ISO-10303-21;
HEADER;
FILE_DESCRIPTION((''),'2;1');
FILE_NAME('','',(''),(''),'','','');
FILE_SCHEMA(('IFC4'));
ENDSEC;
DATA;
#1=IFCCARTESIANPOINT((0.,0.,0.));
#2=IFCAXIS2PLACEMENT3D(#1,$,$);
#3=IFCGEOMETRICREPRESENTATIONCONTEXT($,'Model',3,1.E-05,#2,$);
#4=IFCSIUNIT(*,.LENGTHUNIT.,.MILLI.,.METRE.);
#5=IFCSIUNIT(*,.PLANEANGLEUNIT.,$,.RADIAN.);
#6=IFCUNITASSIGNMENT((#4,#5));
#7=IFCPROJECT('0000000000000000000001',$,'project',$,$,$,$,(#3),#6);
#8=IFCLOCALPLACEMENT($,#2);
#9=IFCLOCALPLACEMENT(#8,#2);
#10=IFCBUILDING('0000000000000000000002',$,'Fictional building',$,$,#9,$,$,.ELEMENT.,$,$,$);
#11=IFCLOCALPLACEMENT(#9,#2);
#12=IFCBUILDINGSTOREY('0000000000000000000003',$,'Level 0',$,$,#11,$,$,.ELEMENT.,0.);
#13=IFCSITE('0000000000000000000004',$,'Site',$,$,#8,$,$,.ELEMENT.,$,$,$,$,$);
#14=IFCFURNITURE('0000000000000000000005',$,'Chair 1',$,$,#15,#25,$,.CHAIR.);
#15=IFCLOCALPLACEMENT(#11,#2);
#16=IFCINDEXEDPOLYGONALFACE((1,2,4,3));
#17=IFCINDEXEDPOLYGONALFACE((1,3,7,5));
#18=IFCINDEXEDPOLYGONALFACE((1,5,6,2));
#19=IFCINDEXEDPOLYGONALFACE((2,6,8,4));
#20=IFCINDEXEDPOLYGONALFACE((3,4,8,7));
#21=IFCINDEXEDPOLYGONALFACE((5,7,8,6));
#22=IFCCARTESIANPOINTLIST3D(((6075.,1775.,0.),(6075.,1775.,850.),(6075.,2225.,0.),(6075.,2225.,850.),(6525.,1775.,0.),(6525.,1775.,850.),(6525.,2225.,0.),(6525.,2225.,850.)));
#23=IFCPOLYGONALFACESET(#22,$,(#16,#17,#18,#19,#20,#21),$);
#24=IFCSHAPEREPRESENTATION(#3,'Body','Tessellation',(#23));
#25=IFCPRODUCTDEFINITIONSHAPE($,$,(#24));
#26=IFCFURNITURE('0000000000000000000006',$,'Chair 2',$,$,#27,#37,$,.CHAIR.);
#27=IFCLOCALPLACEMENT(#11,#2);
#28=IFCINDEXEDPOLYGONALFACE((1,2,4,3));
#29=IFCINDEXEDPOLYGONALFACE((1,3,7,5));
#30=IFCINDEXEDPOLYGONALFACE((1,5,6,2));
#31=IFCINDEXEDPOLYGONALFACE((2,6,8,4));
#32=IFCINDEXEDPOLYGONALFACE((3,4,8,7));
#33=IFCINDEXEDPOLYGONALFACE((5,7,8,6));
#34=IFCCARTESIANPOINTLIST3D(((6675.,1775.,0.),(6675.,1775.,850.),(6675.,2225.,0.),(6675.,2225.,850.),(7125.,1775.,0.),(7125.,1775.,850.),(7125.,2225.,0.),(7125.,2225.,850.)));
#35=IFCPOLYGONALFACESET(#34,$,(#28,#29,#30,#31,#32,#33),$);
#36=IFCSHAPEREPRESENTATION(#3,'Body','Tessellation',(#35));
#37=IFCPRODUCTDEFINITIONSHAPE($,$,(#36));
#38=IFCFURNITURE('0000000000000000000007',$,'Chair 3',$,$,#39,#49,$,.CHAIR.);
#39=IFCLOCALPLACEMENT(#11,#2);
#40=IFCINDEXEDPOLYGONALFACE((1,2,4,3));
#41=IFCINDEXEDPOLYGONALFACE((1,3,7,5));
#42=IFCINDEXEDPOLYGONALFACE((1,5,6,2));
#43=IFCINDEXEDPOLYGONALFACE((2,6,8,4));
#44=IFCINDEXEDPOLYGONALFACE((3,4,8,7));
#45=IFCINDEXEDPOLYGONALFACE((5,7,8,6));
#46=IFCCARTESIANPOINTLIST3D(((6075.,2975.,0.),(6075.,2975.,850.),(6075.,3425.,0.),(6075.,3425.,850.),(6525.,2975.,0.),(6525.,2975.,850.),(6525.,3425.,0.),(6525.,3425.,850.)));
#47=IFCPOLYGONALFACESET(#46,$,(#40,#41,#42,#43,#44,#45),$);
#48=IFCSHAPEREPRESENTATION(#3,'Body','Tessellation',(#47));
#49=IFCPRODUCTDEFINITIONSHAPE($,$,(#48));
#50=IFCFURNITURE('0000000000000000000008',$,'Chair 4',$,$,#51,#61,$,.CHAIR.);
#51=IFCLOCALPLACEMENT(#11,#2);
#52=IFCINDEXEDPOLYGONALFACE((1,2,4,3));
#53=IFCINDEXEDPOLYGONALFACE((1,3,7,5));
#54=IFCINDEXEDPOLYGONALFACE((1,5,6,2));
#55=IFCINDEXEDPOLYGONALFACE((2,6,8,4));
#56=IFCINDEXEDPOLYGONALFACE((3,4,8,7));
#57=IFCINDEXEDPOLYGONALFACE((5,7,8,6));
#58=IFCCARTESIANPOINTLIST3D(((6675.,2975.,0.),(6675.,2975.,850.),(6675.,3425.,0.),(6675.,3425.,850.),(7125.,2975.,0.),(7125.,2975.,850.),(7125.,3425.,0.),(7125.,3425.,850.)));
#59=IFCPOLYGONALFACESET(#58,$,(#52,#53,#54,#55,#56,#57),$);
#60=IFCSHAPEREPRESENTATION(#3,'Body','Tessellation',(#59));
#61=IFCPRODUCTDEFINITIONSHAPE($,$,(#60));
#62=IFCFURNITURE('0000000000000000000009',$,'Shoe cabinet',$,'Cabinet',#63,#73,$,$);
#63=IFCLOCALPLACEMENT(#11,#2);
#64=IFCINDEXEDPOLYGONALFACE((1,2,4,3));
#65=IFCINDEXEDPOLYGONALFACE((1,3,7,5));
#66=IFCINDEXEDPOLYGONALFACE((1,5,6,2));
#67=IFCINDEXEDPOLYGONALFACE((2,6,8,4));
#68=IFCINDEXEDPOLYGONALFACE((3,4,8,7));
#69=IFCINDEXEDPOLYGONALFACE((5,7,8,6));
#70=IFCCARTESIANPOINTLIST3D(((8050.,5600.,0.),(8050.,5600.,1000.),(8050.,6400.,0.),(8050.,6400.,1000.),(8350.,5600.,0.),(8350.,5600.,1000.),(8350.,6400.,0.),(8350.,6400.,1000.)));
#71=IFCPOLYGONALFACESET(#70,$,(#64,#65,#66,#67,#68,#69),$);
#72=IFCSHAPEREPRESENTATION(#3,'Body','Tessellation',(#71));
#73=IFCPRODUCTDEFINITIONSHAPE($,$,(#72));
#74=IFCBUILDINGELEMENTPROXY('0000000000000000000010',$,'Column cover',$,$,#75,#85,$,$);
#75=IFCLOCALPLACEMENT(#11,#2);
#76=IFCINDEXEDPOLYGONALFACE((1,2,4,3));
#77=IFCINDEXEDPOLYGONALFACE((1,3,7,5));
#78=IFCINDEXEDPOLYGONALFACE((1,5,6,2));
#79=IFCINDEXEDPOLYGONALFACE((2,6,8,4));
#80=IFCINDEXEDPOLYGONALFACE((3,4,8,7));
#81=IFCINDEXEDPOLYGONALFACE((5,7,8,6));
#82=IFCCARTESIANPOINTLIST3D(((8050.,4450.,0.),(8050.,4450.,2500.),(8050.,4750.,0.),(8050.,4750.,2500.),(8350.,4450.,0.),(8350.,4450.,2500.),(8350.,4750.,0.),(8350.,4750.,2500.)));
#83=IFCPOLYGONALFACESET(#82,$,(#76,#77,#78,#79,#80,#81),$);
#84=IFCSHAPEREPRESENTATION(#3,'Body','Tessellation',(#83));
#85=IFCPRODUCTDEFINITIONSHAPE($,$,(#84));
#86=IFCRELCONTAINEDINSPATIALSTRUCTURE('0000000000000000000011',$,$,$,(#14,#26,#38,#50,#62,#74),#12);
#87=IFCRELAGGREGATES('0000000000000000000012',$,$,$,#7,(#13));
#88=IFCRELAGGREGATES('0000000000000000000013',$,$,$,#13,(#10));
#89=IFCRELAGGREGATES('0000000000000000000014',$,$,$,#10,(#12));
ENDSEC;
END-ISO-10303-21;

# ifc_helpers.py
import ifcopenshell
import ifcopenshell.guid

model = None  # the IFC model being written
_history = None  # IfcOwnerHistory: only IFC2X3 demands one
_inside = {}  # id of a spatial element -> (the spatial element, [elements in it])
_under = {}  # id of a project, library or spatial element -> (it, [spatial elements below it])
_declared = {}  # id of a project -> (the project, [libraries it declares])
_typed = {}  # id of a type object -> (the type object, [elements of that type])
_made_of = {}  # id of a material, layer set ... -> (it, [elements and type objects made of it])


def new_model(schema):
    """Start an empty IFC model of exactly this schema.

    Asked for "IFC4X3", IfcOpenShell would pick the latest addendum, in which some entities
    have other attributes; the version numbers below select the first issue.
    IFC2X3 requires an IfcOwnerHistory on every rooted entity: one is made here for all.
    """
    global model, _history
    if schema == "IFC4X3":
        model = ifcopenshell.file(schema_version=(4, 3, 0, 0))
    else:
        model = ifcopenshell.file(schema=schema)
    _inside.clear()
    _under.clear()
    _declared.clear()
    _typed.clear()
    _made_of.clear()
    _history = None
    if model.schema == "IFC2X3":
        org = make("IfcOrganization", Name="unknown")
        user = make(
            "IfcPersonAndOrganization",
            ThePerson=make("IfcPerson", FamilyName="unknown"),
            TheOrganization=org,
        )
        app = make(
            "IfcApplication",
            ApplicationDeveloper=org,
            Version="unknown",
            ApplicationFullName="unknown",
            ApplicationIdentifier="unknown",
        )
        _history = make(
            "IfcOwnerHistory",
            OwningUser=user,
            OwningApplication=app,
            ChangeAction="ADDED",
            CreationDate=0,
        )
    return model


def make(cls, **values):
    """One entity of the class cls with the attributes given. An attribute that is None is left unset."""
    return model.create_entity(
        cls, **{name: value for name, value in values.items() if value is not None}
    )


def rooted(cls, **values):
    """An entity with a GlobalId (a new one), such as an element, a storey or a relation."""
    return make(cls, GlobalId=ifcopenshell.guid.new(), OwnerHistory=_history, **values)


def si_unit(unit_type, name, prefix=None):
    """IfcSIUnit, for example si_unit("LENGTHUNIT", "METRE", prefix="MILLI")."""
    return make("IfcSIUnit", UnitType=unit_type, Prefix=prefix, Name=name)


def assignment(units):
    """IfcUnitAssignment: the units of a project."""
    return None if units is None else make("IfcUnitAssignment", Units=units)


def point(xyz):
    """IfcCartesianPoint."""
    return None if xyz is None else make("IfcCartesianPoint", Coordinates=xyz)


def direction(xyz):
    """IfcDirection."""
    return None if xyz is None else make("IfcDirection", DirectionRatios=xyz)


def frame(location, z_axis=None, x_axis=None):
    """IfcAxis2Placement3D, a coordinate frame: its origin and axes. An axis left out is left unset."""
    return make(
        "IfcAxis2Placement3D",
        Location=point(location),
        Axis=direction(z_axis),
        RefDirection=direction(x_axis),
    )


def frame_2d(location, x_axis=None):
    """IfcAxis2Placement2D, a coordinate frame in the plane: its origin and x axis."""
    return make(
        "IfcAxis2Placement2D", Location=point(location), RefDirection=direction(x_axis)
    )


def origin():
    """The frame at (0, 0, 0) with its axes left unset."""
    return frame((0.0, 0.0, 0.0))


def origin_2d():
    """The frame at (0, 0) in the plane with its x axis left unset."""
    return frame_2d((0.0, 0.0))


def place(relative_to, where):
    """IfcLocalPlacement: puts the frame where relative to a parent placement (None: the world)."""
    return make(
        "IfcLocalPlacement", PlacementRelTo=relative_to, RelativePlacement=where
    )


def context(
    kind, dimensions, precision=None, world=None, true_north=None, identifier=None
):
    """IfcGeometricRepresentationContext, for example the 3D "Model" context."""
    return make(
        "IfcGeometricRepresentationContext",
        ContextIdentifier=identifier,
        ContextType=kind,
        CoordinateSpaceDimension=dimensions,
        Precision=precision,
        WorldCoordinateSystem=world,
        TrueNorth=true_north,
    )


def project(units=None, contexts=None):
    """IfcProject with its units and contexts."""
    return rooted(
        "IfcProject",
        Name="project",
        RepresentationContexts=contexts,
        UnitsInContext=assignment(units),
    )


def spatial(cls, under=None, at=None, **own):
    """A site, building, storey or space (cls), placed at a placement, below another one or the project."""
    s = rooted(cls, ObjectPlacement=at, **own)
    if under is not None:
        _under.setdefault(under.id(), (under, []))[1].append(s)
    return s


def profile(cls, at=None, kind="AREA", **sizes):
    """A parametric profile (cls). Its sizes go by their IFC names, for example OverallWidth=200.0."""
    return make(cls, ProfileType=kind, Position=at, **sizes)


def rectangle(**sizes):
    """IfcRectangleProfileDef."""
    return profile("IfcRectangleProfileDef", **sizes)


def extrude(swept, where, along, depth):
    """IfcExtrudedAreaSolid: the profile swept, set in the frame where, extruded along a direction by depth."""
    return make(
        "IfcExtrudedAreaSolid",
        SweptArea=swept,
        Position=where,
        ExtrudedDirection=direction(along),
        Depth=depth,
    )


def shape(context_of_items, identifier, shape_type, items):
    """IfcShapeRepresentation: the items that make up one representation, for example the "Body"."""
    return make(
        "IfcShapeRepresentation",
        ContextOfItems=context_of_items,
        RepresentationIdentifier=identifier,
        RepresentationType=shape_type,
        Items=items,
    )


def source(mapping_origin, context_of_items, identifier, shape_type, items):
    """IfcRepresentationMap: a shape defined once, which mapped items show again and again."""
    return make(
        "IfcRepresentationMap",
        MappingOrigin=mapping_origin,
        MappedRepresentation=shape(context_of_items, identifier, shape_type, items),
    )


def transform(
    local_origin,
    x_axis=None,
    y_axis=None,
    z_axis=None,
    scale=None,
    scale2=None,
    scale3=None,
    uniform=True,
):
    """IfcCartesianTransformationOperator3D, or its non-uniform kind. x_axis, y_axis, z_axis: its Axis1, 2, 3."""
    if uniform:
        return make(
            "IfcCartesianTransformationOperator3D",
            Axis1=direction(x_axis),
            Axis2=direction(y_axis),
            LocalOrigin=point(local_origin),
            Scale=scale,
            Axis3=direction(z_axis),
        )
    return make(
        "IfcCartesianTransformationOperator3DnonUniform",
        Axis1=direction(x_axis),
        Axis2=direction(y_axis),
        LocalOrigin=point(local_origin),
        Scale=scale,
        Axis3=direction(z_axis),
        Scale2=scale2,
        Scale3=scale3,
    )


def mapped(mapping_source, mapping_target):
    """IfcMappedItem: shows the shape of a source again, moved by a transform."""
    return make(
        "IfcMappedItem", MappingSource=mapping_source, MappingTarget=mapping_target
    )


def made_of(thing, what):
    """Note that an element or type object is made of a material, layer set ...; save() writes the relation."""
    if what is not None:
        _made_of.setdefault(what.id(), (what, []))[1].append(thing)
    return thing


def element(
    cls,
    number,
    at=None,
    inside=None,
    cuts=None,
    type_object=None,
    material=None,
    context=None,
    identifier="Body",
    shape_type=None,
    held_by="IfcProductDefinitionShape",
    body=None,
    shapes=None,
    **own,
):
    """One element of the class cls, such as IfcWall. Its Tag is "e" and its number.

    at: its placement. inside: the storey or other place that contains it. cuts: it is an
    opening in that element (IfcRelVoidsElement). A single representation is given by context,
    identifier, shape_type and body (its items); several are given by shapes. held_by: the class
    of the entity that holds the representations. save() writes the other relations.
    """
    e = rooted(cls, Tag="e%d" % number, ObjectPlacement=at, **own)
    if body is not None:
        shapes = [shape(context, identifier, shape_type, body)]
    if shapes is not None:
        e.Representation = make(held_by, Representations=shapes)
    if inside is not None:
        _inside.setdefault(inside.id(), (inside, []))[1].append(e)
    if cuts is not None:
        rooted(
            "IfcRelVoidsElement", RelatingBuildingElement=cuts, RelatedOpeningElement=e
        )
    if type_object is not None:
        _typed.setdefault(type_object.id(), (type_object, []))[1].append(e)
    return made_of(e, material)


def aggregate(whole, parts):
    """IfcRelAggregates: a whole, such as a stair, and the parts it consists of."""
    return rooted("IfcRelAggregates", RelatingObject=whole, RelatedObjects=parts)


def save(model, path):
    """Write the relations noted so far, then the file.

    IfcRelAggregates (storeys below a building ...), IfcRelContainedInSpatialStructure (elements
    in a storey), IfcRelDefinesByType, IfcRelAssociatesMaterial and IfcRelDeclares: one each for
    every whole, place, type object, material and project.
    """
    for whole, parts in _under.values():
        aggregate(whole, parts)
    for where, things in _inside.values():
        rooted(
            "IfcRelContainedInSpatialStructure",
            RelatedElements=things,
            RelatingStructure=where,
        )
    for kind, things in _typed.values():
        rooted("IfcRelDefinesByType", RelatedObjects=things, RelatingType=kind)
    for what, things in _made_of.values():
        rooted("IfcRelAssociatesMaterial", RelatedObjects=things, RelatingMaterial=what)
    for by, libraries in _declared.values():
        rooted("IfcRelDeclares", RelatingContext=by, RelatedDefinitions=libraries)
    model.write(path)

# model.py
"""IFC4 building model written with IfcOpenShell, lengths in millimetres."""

from ifc_helpers import new_model, si_unit, frame, origin, origin_2d, place, context, project, spatial, rectangle, extrude, source, transform, mapped, element, save


model = new_model("IFC4")

# Units and contexts
model_context = context("Model", 3, precision=1e-05, world=origin())
ifc_project = project(units=[si_unit("LENGTHUNIT", "METRE", prefix="MILLI"), si_unit("PLANEANGLEUNIT", "RADIAN")], contexts=[model_context])

# Site, building, storey
site_placement = place(None, origin())
site = spatial("IfcSite", under=ifc_project, at=site_placement, Name="Site", CompositionType="ELEMENT")
building_placement = place(site_placement, origin())
building = spatial("IfcBuilding", under=site, at=building_placement, Name="Fictional building", CompositionType="ELEMENT")
storey_placement = place(building_placement, origin())
storey = spatial("IfcBuildingStorey", under=building, at=storey_placement, Name="Level 0", CompositionType="ELEMENT", Elevation=0.0)

# Furniture
shared_shape_1 = source(origin(), model_context, "Body", "SweptSolid", [
    extrude(rectangle(XDim=450.0, YDim=450.0, at=origin_2d()), origin(), (0.0, 0.0, 1.0), 850.0),
])
for number, where, name in (
    (1, (6300.0, 2000.0, 0.0), "Chair 1"),
    (2, (6900.0, 2000.0, 0.0), "Chair 2"),
):
    element("IfcFurniture", number, at=place(storey_placement, frame(where)), inside=storey, Name=name, PredefinedType="CHAIR", context=model_context, shape_type="MappedRepresentation", body=[
        mapped(shared_shape_1, transform((0.0, 0.0, 0.0), scale=1.0)),
    ])
for number, where, z_axis, x_axis, name in (
    (3, (6300.0, 3200.0, 0.0), (0.0, 0.0, 1.0), (-1.0, 0.0, 0.0), "Chair 3"),
    (4, (6900.0, 3200.0, 0.0), (0.0, 0.0, 1.0), (-1.0, 0.0, 0.0), "Chair 4"),
):
    element("IfcFurniture", number, at=place(storey_placement, frame(where, z_axis=z_axis, x_axis=x_axis)), inside=storey, Name=name, PredefinedType="CHAIR", context=model_context, shape_type="MappedRepresentation", body=[
        mapped(shared_shape_1, transform((0.0, 0.0, 0.0), scale=1.0)),
    ])
shared_shape_2 = source(origin(), model_context, "Body", "SweptSolid", [
    extrude(rectangle(XDim=800.0, YDim=300.0, at=origin_2d()), origin(), (0.0, 0.0, 1.0), 1000.0),
])
furniture_1_placement = place(storey_placement, frame((8200.0, 6000.0, 0.0), z_axis=(0.0, 0.0, 1.0), x_axis=(0.0, 1.0, 0.0)))
element("IfcFurniture", 5, at=furniture_1_placement, inside=storey, Name="Shoe cabinet", ObjectType="Cabinet", context=model_context, shape_type="MappedRepresentation", body=[
    mapped(shared_shape_2, transform((0.0, 0.0, 0.0), scale=1.0)),
])

# Building element proxy
shared_shape_3 = source(origin(), model_context, "Body", "SweptSolid", [
    extrude(rectangle(XDim=300.0, YDim=300.0, at=origin_2d()), origin(), (0.0, 0.0, 1.0), 2500.0),
])
proxy_placement = place(storey_placement, frame((8200.0, 4600.0, 0.0)))
element("IfcBuildingElementProxy", 6, at=proxy_placement, inside=storey, Name="Column cover", context=model_context, shape_type="MappedRepresentation", body=[
    mapped(shared_shape_3, transform((0.0, 0.0, 0.0), scale=1.0)),
])

save(model, "model.ifc")
